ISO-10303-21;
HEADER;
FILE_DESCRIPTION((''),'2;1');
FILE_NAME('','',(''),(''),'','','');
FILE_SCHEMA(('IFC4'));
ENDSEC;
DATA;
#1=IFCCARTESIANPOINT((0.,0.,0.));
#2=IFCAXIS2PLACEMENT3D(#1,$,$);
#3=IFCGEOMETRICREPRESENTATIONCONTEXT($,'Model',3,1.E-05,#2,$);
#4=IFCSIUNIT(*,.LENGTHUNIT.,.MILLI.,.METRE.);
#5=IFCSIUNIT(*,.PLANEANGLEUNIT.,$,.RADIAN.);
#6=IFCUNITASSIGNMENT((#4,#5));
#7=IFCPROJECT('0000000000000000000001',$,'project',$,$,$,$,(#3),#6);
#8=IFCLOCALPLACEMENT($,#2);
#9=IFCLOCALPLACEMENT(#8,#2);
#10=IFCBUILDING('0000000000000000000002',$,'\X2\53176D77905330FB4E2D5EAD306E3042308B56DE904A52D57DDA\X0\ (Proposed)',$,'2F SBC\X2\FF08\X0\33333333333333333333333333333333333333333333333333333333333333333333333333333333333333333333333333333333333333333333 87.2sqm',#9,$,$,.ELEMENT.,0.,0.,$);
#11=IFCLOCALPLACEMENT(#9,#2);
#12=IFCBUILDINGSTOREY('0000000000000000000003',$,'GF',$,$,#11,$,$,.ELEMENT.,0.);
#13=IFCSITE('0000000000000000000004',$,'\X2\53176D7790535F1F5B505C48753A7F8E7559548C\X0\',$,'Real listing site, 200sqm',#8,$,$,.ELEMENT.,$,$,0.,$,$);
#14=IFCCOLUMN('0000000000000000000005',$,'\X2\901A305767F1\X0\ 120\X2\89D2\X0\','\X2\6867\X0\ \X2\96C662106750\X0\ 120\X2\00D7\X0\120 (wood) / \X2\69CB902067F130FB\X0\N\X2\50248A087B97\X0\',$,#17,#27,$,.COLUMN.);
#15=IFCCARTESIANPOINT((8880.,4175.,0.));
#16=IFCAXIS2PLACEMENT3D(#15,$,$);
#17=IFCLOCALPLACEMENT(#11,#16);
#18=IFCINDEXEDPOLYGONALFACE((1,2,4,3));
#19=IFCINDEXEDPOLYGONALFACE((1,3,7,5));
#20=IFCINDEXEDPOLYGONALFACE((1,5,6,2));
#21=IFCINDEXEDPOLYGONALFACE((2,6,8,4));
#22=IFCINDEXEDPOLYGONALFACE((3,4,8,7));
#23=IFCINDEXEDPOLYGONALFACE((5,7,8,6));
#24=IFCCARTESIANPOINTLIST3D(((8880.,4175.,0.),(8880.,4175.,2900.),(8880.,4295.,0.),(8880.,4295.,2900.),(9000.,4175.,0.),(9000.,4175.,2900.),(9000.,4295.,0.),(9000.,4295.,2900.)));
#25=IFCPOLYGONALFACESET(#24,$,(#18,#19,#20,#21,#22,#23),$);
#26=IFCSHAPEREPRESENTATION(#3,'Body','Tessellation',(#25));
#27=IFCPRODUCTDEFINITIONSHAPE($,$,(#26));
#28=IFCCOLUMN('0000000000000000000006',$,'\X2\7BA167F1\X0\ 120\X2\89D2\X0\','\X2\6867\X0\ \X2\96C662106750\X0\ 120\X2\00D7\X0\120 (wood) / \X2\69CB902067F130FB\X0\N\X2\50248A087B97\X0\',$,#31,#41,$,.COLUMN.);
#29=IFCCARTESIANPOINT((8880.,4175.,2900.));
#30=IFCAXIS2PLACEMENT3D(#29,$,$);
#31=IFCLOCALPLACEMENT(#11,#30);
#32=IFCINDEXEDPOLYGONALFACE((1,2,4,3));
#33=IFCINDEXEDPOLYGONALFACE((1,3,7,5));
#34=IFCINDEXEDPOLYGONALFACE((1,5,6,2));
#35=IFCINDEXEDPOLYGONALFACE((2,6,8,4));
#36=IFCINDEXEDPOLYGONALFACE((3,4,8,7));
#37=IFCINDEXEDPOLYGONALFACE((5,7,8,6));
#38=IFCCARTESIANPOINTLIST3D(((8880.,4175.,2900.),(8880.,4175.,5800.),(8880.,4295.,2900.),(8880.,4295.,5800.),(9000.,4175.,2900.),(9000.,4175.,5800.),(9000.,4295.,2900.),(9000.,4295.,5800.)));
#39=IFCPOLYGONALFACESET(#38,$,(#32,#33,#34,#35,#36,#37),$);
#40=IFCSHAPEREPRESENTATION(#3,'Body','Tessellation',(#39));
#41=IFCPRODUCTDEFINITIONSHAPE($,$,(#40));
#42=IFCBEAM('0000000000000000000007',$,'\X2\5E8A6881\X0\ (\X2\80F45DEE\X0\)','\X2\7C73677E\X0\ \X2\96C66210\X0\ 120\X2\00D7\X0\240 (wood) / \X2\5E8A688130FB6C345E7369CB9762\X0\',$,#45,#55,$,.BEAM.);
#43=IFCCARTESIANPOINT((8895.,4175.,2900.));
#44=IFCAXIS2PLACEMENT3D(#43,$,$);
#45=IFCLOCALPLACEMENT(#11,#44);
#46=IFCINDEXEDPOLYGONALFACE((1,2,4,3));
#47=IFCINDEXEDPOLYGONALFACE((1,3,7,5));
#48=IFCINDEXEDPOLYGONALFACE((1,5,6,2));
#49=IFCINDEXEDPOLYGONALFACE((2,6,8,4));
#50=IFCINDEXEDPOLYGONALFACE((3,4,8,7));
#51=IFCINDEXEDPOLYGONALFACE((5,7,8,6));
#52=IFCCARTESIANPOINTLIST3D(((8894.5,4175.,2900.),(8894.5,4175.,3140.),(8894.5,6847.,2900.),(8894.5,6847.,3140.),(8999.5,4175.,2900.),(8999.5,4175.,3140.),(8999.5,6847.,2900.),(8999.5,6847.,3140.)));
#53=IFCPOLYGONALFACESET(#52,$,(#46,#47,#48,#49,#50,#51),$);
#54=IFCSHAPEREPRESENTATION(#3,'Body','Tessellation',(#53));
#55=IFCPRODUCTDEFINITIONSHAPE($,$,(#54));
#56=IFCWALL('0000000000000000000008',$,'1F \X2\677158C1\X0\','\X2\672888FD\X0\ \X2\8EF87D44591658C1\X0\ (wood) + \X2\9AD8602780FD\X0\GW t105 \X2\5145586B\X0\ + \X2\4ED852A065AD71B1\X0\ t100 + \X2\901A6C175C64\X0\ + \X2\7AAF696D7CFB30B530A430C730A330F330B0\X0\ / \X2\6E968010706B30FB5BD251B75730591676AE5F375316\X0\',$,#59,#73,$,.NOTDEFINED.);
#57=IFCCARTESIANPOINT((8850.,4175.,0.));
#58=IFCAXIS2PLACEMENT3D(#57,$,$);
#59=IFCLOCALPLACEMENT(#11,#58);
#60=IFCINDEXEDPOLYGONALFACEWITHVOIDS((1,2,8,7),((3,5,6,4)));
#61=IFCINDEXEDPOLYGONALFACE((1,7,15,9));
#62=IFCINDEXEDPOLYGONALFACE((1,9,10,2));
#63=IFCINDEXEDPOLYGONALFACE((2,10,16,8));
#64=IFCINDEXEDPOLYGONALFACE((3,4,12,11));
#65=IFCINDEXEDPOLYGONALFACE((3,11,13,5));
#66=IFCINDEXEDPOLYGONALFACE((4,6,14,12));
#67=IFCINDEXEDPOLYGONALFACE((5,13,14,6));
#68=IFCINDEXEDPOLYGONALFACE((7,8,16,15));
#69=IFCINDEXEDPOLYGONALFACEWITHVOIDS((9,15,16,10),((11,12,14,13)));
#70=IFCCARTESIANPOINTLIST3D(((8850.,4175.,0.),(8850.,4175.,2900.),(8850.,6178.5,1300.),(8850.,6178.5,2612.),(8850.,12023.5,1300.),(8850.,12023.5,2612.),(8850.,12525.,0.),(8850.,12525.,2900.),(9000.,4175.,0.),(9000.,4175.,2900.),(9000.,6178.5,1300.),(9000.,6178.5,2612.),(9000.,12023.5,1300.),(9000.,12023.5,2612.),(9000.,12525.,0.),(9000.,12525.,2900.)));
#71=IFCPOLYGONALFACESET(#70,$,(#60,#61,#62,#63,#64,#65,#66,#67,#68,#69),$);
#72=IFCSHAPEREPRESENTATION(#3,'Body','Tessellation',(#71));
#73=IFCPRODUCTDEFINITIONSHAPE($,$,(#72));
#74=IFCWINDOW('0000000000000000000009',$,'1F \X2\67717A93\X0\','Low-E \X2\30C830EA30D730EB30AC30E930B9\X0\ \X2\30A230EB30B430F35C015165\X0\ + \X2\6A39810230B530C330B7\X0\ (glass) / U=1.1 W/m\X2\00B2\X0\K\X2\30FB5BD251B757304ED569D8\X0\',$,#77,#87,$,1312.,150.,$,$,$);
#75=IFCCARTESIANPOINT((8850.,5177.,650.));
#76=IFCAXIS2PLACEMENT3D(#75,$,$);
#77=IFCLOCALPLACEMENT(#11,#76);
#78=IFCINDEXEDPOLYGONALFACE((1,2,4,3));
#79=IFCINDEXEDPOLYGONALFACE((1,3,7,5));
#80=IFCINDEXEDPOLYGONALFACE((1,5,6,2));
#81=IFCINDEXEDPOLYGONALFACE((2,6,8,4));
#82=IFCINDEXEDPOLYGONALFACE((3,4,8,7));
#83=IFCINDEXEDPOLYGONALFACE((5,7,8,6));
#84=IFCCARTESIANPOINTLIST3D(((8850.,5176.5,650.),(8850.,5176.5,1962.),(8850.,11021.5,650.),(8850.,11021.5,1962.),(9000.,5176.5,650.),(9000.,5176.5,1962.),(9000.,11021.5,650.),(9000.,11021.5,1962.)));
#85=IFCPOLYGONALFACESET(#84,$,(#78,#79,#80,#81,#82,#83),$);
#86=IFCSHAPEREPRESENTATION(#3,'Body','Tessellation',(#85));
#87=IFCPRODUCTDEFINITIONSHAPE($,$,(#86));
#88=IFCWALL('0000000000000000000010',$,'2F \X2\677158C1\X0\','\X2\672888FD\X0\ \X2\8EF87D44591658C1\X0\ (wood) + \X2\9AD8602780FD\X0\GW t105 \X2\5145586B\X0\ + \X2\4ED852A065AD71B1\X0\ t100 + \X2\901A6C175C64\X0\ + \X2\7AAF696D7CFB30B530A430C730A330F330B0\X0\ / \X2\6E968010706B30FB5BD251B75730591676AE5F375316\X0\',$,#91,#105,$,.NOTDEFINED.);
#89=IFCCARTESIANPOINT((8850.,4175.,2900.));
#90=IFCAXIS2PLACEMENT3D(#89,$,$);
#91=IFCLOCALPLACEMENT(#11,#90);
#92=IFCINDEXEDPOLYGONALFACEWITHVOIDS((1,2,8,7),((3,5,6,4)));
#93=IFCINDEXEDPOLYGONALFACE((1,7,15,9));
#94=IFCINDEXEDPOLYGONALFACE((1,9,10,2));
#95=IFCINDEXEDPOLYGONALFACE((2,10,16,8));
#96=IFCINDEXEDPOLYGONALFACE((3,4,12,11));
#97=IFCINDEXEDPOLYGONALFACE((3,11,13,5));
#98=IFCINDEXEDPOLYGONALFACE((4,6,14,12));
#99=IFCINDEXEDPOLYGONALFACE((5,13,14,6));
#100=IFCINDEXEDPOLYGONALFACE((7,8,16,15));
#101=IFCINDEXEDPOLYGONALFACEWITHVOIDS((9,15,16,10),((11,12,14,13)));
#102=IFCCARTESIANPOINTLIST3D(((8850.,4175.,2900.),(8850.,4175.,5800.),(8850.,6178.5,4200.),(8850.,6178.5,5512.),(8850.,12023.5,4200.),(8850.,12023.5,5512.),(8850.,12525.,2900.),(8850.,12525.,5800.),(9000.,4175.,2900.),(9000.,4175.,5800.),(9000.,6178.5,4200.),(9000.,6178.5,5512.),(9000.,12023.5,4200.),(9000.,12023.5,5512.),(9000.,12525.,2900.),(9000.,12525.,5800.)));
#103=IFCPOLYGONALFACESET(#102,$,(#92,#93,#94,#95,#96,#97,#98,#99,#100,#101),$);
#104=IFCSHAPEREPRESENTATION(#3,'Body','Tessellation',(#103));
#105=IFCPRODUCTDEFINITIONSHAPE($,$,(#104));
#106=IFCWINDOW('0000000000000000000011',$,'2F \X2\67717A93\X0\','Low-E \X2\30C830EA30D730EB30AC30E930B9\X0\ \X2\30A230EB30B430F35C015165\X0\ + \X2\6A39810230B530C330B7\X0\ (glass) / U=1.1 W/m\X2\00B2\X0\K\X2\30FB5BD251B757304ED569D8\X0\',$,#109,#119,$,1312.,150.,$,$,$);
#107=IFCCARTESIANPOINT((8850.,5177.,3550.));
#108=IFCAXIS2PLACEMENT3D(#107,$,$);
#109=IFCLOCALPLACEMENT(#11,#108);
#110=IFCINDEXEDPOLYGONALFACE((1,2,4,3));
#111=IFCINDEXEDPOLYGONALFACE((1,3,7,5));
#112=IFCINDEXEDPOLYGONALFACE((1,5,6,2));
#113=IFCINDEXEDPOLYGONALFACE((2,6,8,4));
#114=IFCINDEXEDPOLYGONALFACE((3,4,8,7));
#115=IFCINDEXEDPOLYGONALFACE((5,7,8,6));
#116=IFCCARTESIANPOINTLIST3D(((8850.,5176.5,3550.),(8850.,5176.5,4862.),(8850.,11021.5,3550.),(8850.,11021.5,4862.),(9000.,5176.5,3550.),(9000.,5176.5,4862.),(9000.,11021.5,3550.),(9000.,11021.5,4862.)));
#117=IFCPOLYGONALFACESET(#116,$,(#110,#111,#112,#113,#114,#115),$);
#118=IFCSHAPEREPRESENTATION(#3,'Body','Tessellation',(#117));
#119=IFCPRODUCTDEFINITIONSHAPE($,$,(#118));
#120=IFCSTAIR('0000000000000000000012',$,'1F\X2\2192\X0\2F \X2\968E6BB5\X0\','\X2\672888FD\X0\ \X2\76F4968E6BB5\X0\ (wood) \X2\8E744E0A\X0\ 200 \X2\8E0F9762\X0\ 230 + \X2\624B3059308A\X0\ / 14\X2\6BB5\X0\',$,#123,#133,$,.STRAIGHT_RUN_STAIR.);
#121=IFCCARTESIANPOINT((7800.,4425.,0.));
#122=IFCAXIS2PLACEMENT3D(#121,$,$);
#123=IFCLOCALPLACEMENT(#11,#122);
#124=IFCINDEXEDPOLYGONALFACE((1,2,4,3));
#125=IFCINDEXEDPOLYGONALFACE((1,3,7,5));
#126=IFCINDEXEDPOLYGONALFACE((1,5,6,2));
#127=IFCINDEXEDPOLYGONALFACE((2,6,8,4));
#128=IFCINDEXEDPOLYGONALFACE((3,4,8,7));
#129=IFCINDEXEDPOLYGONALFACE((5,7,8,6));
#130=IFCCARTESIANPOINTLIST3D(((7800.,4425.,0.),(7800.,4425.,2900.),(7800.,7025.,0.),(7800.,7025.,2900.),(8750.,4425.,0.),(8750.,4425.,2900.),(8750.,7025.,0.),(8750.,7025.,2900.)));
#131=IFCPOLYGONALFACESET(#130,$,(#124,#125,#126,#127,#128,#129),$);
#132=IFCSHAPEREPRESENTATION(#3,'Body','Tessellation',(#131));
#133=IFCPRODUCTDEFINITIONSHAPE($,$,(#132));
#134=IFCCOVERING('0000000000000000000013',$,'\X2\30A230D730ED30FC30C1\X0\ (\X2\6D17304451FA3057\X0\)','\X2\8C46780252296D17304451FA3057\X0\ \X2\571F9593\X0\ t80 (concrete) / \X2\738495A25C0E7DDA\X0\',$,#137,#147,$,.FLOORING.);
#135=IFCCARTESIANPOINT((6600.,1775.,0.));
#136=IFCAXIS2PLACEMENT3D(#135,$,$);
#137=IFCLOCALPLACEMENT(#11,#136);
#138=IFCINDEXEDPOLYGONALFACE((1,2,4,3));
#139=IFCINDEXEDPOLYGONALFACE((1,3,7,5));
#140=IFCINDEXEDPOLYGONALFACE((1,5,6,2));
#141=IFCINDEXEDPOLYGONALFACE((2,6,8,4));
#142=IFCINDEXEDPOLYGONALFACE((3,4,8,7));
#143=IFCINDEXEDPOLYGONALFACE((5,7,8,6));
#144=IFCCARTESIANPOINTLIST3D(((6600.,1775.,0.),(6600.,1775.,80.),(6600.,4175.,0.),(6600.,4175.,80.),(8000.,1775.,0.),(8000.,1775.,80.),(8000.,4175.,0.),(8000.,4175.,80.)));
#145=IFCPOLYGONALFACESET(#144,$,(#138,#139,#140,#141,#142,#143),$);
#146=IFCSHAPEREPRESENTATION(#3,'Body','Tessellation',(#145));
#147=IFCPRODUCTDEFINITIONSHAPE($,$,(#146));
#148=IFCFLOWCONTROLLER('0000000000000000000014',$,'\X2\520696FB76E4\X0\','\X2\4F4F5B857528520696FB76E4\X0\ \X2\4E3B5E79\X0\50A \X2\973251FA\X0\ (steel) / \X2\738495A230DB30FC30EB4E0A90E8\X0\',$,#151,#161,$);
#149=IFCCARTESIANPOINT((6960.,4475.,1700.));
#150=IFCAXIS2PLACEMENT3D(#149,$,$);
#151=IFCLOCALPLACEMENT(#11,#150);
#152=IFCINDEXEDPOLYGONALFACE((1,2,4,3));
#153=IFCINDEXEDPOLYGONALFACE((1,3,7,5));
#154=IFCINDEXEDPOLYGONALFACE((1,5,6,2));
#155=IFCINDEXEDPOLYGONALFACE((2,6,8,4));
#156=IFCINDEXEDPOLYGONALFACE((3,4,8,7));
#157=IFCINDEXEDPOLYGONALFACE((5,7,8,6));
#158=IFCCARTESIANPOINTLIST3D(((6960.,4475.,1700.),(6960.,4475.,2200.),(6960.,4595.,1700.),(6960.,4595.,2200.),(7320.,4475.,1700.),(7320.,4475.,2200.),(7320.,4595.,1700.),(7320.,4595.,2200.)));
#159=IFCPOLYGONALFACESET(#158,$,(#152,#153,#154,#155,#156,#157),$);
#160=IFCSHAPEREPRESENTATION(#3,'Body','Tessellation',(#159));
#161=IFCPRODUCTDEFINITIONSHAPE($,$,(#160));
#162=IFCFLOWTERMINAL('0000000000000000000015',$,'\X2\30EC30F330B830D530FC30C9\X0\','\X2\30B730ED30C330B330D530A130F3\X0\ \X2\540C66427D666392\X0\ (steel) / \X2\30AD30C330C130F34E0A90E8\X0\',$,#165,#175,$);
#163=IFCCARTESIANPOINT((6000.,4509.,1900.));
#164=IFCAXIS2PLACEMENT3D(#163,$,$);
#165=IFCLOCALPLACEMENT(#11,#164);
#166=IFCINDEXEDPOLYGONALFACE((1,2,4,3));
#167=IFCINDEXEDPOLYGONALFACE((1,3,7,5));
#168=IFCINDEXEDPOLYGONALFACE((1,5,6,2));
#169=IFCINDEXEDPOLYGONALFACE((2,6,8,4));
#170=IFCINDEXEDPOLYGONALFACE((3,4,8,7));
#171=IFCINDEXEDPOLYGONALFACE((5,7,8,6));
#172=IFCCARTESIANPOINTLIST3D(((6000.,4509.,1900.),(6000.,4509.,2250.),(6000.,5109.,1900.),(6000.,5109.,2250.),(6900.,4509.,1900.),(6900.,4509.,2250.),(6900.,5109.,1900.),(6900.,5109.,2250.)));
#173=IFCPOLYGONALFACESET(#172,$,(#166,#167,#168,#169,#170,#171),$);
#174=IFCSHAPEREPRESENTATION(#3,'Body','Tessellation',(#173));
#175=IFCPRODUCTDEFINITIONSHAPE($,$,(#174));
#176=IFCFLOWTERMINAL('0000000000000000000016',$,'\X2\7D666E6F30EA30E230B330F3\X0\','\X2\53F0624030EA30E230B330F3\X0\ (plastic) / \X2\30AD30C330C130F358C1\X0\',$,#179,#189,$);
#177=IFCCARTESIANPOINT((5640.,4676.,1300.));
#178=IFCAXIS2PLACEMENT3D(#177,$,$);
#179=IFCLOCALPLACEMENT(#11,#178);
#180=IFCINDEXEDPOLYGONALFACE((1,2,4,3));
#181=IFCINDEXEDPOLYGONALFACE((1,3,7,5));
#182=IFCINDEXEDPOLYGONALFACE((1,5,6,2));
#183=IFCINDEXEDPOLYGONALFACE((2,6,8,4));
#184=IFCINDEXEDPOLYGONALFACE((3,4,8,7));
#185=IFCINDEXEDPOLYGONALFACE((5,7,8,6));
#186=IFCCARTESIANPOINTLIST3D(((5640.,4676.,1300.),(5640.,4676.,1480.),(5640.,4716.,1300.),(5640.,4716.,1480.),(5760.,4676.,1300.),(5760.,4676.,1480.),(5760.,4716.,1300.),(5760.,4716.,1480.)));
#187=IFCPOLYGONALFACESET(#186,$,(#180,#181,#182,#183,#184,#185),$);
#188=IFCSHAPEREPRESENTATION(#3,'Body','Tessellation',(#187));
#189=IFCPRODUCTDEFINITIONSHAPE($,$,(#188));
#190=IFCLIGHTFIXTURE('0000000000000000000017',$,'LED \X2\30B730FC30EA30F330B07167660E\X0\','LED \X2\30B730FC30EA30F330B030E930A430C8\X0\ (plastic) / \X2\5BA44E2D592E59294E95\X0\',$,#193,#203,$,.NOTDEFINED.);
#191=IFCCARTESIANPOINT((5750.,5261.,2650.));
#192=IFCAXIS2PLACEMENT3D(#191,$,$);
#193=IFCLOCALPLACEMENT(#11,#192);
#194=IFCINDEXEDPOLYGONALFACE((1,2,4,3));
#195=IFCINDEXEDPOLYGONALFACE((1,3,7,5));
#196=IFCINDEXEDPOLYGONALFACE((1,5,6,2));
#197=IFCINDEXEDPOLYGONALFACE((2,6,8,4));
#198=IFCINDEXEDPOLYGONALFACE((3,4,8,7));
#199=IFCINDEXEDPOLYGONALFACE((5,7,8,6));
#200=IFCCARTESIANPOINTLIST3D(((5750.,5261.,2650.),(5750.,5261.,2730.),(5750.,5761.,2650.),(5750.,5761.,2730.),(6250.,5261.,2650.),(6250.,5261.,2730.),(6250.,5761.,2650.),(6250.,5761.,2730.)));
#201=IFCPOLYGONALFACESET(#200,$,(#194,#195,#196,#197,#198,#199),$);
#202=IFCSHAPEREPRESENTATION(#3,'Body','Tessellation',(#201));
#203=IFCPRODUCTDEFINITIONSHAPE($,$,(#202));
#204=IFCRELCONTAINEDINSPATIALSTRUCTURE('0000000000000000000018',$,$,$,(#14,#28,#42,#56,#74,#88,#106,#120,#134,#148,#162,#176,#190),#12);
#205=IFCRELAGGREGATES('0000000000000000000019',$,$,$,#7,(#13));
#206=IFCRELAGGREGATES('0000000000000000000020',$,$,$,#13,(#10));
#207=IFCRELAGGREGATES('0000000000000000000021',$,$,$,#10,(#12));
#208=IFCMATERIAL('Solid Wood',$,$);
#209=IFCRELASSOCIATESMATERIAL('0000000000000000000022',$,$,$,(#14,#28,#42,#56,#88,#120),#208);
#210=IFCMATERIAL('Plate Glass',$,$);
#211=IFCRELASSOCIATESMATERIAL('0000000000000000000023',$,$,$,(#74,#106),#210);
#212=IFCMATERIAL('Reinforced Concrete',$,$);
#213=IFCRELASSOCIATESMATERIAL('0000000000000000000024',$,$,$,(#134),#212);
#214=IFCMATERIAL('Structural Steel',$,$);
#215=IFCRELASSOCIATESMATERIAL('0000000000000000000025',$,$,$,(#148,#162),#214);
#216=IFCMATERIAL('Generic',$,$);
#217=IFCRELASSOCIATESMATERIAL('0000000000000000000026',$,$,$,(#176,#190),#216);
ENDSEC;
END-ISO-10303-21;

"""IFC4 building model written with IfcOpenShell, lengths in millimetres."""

from ifc_helpers import new_model, si_unit, frame, frame_2d, origin, place, context, project, spatial, rectangle, extrude, material, element, fill, save


model = new_model("IFC4")

# Units and contexts
model_context = context("Model", 3, precision=1e-05, world=origin())
ifc_project = project(units=[si_unit("LENGTHUNIT", "METRE", prefix="MILLI"), si_unit("PLANEANGLEUNIT", "RADIAN")], contexts=[model_context])

# Site, building, storey
site_placement = place(None, origin())
site = spatial("IfcSite", under=ifc_project, at=site_placement, Name="北海道弟子屈町美留和", ObjectType="Real listing site, 200sqm", CompositionType="ELEMENT", RefElevation=0.0)
building_placement = place(site_placement, origin())
building = spatial("IfcBuilding", under=site, at=building_placement, Name="北海道・中庭のある回遊動線 (Proposed)", ObjectType="2F SBC（33333333333333333333333333333333333333333333333333333333333333333333333333333333333333333333333333333333333333333333 87.2sqm", CompositionType="ELEMENT", ElevationOfRefHeight=0.0, ElevationOfTerrain=0.0)
storey_placement = place(building_placement, origin())
storey = spatial("IfcBuildingStorey", under=building, at=storey_placement, Name="GF", CompositionType="ELEMENT", Elevation=0.0)

# Columns
ifc_material_1 = material(Name="Solid Wood")
column_1_placement = place(storey_placement, frame((8880.0, 4175.0, 0.0)))
element("IfcColumn", 1, at=column_1_placement, inside=storey, material=ifc_material_1, Name="通し柱 120角", Description="桧 集成材 120×120 (wood) / 構造柱・N値計算", PredefinedType="COLUMN", context=model_context, shape_type="SweptSolid", body=[
    extrude(rectangle(XDim=120.0, YDim=120.0, at=frame_2d((60.0, 60.0))), frame((8880.0, 4175.0, 0.0)), (0.0, 0.0, 1.0), 2900.0),
])
column_2_placement = place(storey_placement, frame((8880.0, 4175.0, 2900.0)))
element("IfcColumn", 2, at=column_2_placement, inside=storey, material=ifc_material_1, Name="管柱 120角", Description="桧 集成材 120×120 (wood) / 構造柱・N値計算", PredefinedType="COLUMN", context=model_context, shape_type="SweptSolid", body=[
    extrude(rectangle(XDim=120.0, YDim=120.0, at=frame_2d((60.0, 60.0))), frame((8880.0, 4175.0, 2900.0)), (0.0, 0.0, 1.0), 2900.0),
])

# Beam
beam_1_placement = place(storey_placement, frame((8895.0, 4175.0, 2900.0)))
element("IfcBeam", 3, at=beam_1_placement, inside=storey, material=ifc_material_1, Name="床梁 (胴差)", Description="米松 集成 120×240 (wood) / 床梁・水平構面", PredefinedType="BEAM", context=model_context, shape_type="SweptSolid", body=[
    extrude(rectangle(XDim=105.0, YDim=2672.0, at=frame_2d((52.0, 1336.0))), frame((8895.0, 4175.0, 2900.0)), (0.0, 0.0, 1.0), 240.0),
])

# Wall, opening, window
wall_1_placement = place(storey_placement, frame((8850.0, 4175.0, 0.0)))
wall_1 = element("IfcWall", 4, at=wall_1_placement, inside=storey, material=ifc_material_1, Name="1F 東壁", Description="木製 軸組外壁 (wood) + 高性能GW t105 充填 + 付加断熱 t100 + 通気層 + 窯業系サイディング / 準耐火・寒冷地外皮強化", PredefinedType="NOTDEFINED", context=model_context, shape_type="SweptSolid", body=[
    extrude(rectangle(XDim=150.0, YDim=8350.0, at=frame_2d((75.0, 4175.0))), frame((8850.0, 4175.0, 0.0)), (0.0, 0.0, 1.0), 2900.0),
])
opening_1_placement = place(storey_placement, frame((8850.0, 5177.0, 650.0)))
opening_1 = element("IfcOpeningElement", 5, at=opening_1_placement, cuts=wall_1, PredefinedType="NOTDEFINED", context=model_context, shape_type="SweptSolid", body=[
    extrude(rectangle(XDim=150.0, YDim=5845.0, at=frame_2d((75.0, 2922.0))), frame((8850.0, 5177.0, 650.0)), (0.0, 0.0, 1.0), 1312.0),
])
ifc_material_2 = material(Name="Plate Glass")
window_1_placement = place(storey_placement, frame((8850.0, 5177.0, 650.0)))
window_1 = element("IfcWindow", 6, at=window_1_placement, inside=storey, material=ifc_material_2, Name="1F 東窓", Description="Low-E トリプルガラス アルゴン封入 + 樹脂サッシ (glass) / U=1.1 W/m²K・寒冷地仕様", OverallHeight=1312.0, OverallWidth=150.0, context=model_context, shape_type="SweptSolid", body=[
    extrude(rectangle(XDim=150.0, YDim=5845.0, at=frame_2d((75.0, 2922.0))), frame((8850.0, 5177.0, 650.0)), (0.0, 0.0, 1.0), 1312.0),
])
fill(opening_1, window_1)

# Wall, opening, window
wall_2_placement = place(storey_placement, frame((8850.0, 4175.0, 2900.0)))
wall_2 = element("IfcWall", 7, at=wall_2_placement, inside=storey, material=ifc_material_1, Name="2F 東壁", Description="木製 軸組外壁 (wood) + 高性能GW t105 充填 + 付加断熱 t100 + 通気層 + 窯業系サイディング / 準耐火・寒冷地外皮強化", PredefinedType="NOTDEFINED", context=model_context, shape_type="SweptSolid", body=[
    extrude(rectangle(XDim=150.0, YDim=8350.0, at=frame_2d((75.0, 4175.0))), frame((8850.0, 4175.0, 2900.0)), (0.0, 0.0, 1.0), 2900.0),
])
opening_2_placement = place(storey_placement, frame((8850.0, 5177.0, 3550.0)))
opening_2 = element("IfcOpeningElement", 8, at=opening_2_placement, cuts=wall_2, PredefinedType="NOTDEFINED", context=model_context, shape_type="SweptSolid", body=[
    extrude(rectangle(XDim=150.0, YDim=5845.0, at=frame_2d((75.0, 2922.0))), frame((8850.0, 5177.0, 3550.0)), (0.0, 0.0, 1.0), 1312.0),
])
window_2_placement = place(storey_placement, frame((8850.0, 5177.0, 3550.0)))
window_2 = element("IfcWindow", 9, at=window_2_placement, inside=storey, material=ifc_material_2, Name="2F 東窓", Description="Low-E トリプルガラス アルゴン封入 + 樹脂サッシ (glass) / U=1.1 W/m²K・寒冷地仕様", OverallHeight=1312.0, OverallWidth=150.0, context=model_context, shape_type="SweptSolid", body=[
    extrude(rectangle(XDim=150.0, YDim=5845.0, at=frame_2d((75.0, 2922.0))), frame((8850.0, 5177.0, 3550.0)), (0.0, 0.0, 1.0), 1312.0),
])
fill(opening_2, window_2)

# Stair
stair_placement = place(storey_placement, frame((7800.0, 4425.0, 0.0)))
element("IfcStair", 10, at=stair_placement, inside=storey, material=ifc_material_1, Name="1F→2F 階段", Description="木製 直階段 (wood) 蹴上 200 踏面 230 + 手すり / 14段", PredefinedType="STRAIGHT_RUN_STAIR", context=model_context, shape_type="SweptSolid", body=[
    extrude(rectangle(XDim=950.0, YDim=2600.0, at=frame_2d((475.0, 1300.0))), frame((7800.0, 4425.0, 0.0)), (0.0, 0.0, 1.0), 2900.0),
])

# Covering
ifc_material_3 = material(Name="Reinforced Concrete")
covering_placement = place(storey_placement, frame((6600.0, 1775.0, 0.0)))
element("IfcCovering", 11, at=covering_placement, inside=storey, material=ifc_material_3, Name="アプローチ (洗い出し)", Description="豆砂利洗い出し 土間 t80 (concrete) / 玄関導線", PredefinedType="FLOORING", context=model_context, shape_type="SweptSolid", body=[
    extrude(rectangle(XDim=1400.0, YDim=2400.0, at=frame_2d((700.0, 1200.0))), frame((6600.0, 1775.0, 0.0)), (0.0, 0.0, 1.0), 80.0),
])

# Flow controller
ifc_material_4 = material(Name="Structural Steel")
flow_controller_placement = place(storey_placement, frame((6960.0, 4475.0, 1700.0)))
element("IfcFlowController", 12, at=flow_controller_placement, inside=storey, material=ifc_material_4, Name="分電盤", Description="住宅用分電盤 主幹50A 露出 (steel) / 玄関ホール上部", context=model_context, shape_type="SweptSolid", body=[
    extrude(rectangle(XDim=360.0, YDim=120.0, at=frame_2d((180.0, 60.0))), frame((6960.0, 4475.0, 1700.0)), (0.0, 0.0, 1.0), 500.0),
])

# Flow terminals
flow_terminal_1_placement = place(storey_placement, frame((6000.0, 4509.0, 1900.0)))
element("IfcFlowTerminal", 13, at=flow_terminal_1_placement, inside=storey, material=ifc_material_4, Name="レンジフード", Description="シロッコファン 同時給排 (steel) / キッチン上部", context=model_context, shape_type="SweptSolid", body=[
    extrude(rectangle(XDim=900.0, YDim=600.0, at=frame_2d((450.0, 300.0))), frame((6000.0, 4509.0, 1900.0)), (0.0, 0.0, 1.0), 350.0),
])
ifc_material_5 = material(Name="Generic")
flow_terminal_2_placement = place(storey_placement, frame((5640.0, 4676.0, 1300.0)))
element("IfcFlowTerminal", 14, at=flow_terminal_2_placement, inside=storey, material=ifc_material_5, Name="給湯リモコン", Description="台所リモコン (plastic) / キッチン壁", context=model_context, shape_type="SweptSolid", body=[
    extrude(rectangle(XDim=120.0, YDim=40.0, at=frame_2d((60.0, 20.0))), frame((5640.0, 4676.0, 1300.0)), (0.0, 0.0, 1.0), 180.0),
])

# Light fixture
light_fixture_1_placement = place(storey_placement, frame((5750.0, 5261.0, 2650.0)))
element("IfcLightFixture", 15, at=light_fixture_1_placement, inside=storey, material=ifc_material_5, Name="LED シーリング照明", Description="LED シーリングライト (plastic) / 室中央天井", PredefinedType="NOTDEFINED", context=model_context, shape_type="SweptSolid", body=[
    extrude(rectangle(XDim=500.0, YDim=500.0, at=frame_2d((250.0, 250.0))), frame((5750.0, 5261.0, 2650.0)), (0.0, 0.0, 1.0), 80.0),
])

save(model, "model.ifc")
